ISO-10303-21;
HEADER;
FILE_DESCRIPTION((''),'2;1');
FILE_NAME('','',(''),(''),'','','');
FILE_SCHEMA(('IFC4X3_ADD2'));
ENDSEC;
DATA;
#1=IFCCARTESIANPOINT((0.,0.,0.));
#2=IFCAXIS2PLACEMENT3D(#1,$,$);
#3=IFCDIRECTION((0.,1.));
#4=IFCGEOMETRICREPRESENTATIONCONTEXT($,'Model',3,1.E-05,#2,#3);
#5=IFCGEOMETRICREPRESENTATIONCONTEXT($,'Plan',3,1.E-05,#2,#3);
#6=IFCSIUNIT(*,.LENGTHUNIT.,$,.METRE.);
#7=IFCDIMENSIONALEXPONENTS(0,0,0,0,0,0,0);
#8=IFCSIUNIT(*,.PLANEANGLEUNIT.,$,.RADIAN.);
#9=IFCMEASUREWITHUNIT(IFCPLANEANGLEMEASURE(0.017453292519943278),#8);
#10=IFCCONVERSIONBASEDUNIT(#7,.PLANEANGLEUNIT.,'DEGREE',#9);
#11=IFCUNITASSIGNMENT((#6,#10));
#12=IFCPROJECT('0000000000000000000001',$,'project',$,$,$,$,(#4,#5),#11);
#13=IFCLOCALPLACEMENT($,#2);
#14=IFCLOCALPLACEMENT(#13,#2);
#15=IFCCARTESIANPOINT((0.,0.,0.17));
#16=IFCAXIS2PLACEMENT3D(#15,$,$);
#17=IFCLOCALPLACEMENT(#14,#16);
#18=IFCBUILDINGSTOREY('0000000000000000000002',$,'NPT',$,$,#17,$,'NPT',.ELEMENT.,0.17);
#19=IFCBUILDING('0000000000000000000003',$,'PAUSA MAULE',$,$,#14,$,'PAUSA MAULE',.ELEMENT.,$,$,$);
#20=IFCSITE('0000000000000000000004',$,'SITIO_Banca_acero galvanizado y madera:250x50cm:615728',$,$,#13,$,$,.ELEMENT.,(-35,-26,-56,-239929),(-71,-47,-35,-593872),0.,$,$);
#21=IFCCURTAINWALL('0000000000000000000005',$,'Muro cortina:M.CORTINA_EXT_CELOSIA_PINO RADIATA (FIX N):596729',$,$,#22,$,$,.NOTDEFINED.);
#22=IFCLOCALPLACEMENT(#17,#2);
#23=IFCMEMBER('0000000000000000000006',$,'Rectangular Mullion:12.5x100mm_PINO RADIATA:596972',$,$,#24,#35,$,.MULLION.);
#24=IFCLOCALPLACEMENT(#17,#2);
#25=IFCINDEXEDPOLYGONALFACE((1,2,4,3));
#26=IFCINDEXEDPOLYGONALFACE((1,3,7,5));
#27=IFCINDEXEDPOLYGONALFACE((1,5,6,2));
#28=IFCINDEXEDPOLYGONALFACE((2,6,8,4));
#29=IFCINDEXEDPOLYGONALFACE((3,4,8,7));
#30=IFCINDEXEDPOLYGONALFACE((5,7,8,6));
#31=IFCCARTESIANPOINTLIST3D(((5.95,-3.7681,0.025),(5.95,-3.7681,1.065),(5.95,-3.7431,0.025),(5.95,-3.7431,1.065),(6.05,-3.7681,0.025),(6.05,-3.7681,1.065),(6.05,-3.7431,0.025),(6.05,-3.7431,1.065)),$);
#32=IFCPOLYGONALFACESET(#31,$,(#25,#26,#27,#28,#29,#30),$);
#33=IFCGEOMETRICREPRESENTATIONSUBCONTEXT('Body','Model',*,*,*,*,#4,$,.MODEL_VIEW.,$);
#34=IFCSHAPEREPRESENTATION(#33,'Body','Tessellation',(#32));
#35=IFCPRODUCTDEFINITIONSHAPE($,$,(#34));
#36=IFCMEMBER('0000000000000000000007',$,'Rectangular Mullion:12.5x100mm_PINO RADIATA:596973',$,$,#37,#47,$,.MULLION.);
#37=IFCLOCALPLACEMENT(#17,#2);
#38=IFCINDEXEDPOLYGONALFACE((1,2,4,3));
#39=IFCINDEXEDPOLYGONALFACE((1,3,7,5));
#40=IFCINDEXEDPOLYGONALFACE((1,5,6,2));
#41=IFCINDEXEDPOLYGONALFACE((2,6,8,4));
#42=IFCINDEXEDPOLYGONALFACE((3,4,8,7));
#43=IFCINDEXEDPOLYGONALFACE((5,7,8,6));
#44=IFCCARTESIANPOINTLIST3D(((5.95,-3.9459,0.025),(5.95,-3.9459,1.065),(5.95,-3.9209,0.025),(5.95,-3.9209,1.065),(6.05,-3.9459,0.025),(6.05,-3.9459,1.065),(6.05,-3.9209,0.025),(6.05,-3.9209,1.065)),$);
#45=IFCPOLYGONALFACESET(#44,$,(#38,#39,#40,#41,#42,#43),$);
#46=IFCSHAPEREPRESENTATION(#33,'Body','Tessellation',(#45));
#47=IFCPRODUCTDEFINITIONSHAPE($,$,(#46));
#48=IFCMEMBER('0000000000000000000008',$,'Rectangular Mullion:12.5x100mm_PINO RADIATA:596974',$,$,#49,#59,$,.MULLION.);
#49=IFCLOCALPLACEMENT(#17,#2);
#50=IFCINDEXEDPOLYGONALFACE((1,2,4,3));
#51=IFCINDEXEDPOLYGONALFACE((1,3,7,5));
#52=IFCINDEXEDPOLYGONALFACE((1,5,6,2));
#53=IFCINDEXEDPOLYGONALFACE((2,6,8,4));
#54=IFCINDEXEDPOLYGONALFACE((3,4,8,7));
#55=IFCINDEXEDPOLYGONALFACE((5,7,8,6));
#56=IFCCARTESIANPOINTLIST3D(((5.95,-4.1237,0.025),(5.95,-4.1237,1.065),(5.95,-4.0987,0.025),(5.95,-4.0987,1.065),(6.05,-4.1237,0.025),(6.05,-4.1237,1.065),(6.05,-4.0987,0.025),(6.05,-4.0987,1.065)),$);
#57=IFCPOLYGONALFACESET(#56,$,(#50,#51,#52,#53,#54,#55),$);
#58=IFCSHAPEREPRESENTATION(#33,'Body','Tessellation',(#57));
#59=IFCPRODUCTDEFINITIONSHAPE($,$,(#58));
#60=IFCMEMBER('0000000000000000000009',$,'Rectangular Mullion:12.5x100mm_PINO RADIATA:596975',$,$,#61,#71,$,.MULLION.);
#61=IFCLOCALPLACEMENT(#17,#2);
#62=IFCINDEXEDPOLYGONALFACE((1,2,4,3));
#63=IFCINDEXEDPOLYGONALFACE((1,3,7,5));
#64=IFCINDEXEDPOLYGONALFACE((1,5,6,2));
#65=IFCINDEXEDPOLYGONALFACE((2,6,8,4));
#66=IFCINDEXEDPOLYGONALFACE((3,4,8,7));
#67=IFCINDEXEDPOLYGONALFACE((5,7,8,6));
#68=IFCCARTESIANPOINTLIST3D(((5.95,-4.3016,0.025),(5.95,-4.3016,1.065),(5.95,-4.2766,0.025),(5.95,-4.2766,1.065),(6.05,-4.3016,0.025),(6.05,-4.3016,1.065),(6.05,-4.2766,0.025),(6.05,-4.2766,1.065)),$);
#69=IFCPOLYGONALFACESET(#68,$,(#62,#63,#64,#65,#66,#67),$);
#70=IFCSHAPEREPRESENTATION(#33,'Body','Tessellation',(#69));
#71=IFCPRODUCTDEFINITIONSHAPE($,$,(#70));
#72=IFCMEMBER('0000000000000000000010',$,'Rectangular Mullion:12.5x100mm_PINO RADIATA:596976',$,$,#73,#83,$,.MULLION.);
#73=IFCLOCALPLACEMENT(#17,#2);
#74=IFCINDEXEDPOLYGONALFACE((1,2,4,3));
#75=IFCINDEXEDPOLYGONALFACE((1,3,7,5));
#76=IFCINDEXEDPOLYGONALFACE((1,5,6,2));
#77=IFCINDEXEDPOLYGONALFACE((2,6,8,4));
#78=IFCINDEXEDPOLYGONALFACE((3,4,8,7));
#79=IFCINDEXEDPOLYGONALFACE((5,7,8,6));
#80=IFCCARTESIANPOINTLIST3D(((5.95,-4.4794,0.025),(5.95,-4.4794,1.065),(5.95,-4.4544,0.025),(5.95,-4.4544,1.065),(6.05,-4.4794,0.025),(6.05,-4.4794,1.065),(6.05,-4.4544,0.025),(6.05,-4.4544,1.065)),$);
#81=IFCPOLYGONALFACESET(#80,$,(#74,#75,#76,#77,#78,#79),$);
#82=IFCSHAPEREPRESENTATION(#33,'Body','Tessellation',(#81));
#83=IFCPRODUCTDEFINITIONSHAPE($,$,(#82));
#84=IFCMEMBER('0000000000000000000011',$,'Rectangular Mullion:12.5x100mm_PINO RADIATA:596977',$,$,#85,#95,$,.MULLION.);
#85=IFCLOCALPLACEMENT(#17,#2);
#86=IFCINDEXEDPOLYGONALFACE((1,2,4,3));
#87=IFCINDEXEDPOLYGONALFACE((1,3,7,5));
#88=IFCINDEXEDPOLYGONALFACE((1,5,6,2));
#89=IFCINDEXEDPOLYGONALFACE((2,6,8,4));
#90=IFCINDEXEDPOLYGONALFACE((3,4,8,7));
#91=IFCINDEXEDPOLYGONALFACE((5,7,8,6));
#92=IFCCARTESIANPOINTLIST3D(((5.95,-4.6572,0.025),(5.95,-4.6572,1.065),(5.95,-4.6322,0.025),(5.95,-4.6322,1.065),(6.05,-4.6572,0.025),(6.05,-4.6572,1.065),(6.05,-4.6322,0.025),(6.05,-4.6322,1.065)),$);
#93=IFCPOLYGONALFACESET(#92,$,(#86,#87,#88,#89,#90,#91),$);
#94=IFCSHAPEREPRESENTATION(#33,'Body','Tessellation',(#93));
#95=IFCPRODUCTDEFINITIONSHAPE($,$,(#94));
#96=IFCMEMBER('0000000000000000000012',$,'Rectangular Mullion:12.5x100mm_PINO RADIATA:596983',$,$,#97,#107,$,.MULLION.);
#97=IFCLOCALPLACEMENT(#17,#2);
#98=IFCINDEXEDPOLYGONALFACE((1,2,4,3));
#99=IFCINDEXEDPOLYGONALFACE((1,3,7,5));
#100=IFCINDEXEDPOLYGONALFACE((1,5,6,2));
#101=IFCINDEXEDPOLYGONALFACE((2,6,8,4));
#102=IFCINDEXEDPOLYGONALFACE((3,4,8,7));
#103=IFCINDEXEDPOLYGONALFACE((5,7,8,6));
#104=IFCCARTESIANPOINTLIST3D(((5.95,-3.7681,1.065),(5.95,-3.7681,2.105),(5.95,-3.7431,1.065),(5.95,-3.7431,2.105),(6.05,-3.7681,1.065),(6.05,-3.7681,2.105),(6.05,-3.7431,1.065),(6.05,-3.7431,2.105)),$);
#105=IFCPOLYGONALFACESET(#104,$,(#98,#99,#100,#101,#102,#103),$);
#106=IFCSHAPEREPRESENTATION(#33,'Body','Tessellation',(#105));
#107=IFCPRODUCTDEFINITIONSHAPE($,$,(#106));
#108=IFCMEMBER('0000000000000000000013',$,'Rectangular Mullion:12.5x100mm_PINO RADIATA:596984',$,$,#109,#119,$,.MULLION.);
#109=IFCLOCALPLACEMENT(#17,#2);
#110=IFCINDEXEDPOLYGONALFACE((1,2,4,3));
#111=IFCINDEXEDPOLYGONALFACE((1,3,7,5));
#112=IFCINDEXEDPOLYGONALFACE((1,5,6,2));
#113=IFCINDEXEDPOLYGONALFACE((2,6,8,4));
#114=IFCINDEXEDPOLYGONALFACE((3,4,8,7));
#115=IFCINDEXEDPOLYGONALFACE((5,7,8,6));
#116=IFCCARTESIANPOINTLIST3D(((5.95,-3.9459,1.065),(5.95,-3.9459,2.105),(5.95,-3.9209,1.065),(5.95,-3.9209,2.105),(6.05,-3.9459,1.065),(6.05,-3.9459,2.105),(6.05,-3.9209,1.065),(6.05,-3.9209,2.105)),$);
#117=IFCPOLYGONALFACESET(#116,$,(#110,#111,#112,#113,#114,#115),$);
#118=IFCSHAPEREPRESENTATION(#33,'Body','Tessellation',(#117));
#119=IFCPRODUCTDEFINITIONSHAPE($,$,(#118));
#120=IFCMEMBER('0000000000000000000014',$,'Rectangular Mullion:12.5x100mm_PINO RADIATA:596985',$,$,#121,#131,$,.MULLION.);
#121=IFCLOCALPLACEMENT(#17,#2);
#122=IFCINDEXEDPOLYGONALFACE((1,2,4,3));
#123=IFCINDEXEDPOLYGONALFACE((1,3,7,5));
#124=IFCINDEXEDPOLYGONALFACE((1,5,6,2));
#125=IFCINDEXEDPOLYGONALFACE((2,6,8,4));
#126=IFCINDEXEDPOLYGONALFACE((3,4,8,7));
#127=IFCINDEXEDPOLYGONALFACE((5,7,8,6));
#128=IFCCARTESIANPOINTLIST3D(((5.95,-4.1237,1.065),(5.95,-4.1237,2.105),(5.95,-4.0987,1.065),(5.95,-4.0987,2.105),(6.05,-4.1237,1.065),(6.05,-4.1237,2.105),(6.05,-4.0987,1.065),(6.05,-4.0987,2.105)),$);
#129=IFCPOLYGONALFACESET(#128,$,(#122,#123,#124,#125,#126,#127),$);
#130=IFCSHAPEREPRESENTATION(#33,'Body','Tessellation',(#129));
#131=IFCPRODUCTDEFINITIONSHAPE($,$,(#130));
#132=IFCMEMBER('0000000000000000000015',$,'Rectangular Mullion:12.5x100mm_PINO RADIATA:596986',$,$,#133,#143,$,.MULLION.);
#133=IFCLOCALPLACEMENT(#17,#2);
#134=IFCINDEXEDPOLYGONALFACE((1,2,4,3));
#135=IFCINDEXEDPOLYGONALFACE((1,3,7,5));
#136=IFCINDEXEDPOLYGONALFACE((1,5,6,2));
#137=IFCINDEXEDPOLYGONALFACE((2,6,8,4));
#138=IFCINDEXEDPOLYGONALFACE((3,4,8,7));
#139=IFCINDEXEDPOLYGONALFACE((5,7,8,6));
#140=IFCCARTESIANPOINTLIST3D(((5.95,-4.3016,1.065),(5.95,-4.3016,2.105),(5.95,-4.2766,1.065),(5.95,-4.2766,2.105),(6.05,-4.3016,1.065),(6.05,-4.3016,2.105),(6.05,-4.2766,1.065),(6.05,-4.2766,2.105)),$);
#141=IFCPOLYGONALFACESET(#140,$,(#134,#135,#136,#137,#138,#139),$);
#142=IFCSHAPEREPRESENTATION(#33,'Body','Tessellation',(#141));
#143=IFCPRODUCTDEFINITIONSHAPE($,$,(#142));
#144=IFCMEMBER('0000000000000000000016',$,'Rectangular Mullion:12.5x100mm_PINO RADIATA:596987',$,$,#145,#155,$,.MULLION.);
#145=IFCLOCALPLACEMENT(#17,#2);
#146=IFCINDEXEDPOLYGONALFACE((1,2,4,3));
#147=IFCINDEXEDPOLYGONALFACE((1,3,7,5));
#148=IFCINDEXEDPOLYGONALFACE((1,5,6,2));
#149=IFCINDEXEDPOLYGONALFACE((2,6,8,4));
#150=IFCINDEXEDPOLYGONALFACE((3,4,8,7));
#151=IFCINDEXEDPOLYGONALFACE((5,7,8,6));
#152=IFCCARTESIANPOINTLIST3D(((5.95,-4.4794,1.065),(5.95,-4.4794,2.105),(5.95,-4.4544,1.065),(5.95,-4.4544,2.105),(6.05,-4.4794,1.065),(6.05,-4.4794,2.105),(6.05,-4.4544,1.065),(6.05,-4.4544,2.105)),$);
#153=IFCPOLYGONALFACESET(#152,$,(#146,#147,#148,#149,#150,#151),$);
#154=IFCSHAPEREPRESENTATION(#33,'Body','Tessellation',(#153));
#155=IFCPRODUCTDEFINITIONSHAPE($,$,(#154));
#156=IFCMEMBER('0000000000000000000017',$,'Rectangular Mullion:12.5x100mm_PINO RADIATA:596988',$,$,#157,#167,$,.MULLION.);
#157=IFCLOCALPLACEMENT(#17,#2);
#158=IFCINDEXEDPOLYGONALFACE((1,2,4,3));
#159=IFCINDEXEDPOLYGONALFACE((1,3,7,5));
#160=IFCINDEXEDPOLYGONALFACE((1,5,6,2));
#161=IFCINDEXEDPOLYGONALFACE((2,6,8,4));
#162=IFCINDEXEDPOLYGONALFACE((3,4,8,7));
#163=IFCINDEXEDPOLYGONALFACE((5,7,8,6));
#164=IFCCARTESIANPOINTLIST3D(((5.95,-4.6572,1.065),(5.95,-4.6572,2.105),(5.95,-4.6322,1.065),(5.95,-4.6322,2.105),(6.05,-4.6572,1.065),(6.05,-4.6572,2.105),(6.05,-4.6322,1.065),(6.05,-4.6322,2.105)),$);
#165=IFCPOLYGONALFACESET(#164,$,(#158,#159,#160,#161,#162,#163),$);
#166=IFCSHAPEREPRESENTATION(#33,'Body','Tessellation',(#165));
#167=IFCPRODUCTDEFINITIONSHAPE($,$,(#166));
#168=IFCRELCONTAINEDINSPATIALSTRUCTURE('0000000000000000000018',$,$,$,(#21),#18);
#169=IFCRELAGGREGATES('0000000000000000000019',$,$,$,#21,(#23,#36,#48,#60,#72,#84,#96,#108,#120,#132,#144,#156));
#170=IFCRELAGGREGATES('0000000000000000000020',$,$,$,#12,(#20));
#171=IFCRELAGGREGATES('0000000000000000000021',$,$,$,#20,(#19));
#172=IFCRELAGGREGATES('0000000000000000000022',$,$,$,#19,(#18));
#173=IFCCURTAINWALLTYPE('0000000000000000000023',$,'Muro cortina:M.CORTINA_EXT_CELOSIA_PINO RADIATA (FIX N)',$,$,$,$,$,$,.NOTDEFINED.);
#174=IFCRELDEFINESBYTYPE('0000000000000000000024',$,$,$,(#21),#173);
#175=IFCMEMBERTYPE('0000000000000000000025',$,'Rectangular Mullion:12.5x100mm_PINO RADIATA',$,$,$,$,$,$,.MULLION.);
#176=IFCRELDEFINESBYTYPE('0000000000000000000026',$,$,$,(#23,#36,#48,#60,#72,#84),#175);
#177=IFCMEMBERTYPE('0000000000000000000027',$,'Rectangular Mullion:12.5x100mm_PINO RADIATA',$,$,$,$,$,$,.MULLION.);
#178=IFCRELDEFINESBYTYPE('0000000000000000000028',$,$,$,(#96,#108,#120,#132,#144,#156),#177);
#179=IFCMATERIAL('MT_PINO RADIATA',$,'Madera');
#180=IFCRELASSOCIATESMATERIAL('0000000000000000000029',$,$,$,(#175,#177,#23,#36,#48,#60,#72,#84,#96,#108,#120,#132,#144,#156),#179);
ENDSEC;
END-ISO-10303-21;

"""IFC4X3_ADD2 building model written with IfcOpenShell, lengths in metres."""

from ifc_helpers import new_model, entity, si_unit, converted_unit, direction, frame, frame_2d, origin, origin_2d_with_axis, place, context, subcontext, project, spatial, rectangle, extrude, source, transform, mapped, material, material_profile, profile_set, profile_usage, type_object, type_shapes, element, aggregate, save


model = new_model("IFC4X3_ADD2")

# Units and contexts
model_context = context("Model", 3, precision=1e-05, world=origin(), true_north=direction((0.0, 1.0)))
plan_context = context("Plan", 3, precision=1e-05, world=origin(), true_north=direction((0.0, 1.0)))
body_context = subcontext(model_context, "Body", "Model", "MODEL_VIEW")
ifc_project = project(units=[si_unit("LENGTHUNIT", "METRE"), converted_unit("PLANEANGLEUNIT", "DEGREE", entity("IfcPlaneAngleMeasure", 0.017453292519943278), si_unit("PLANEANGLEUNIT", "RADIAN"), dimensions=[0, 0, 0, 0, 0, 0, 0])], contexts=[model_context, plan_context])

# Site, building, storey
site_placement = place(None, origin())
site = spatial("IfcSite", under=ifc_project, at=site_placement, Name="SITIO_Banca_acero galvanizado y madera:250x50cm:615728", CompositionType="ELEMENT", RefLatitude=(-35, -26, -56, -239929), RefLongitude=(-71, -47, -35, -593872), RefElevation=0.0)
building_placement = place(site_placement, origin())
building = spatial("IfcBuilding", under=site, at=building_placement, Name="PAUSA MAULE", LongName="PAUSA MAULE", CompositionType="ELEMENT")
storey_placement = place(building_placement, frame((0.0, 0.0, 0.17)))
storey = spatial("IfcBuildingStorey", under=building, at=storey_placement, Name="NPT", LongName="NPT", CompositionType="ELEMENT", Elevation=0.17)

# Curtain wall, members
curtain_wall_type = type_object("IfcCurtainWallType", Name="Muro cortina:M.CORTINA_EXT_CELOSIA_PINO RADIATA (FIX N)", PredefinedType="NOTDEFINED")
curtain_wall_placement = place(storey_placement, frame((0.0, 0.0, -0.17)))
curtain_wall = element("IfcCurtainWall", 1, at=curtain_wall_placement, inside=storey, type_object=curtain_wall_type, Name="Muro cortina:M.CORTINA_EXT_CELOSIA_PINO RADIATA (FIX N):596729", PredefinedType="NOTDEFINED")
ifc_material = material(Name="MT_PINO RADIATA", Category="Madera")
ifc_material_profile = material_profile(ifc_material, rectangle(XDim=0.025, YDim=0.1, at=frame_2d((0.0, 0.0), x_axis=(1.0, 0.0))), Name="12.5x100mm_PINO RADIATA")
ifc_profile_set = profile_set([ifc_material_profile], Name="12.5x100mm_PINO RADIATA")
ifc_profile_usage = profile_usage(ifc_profile_set)
member_type_1 = type_object("IfcMemberType", Name="Rectangular Mullion:12.5x100mm_PINO RADIATA", PredefinedType="MULLION", material=ifc_profile_set)
shared_shape_1 = source(origin(), body_context, "Body", "SweptSolid", [
    extrude(rectangle(XDim=0.025, YDim=0.1, at=frame_2d((0.0, 0.0), x_axis=(1.0, 0.0))), frame((0.0, 0.0, -1.04), z_axis=(0.0, 0.0, 1.0), x_axis=(-1.0, 0.0, 0.0)), (0.0, 0.0, 1.0), 1.04),
])
type_shapes(member_type_1, [shared_shape_1])
member_1_placement = place(curtain_wall_placement, frame((6.0, -3.7556, 0.195), z_axis=(0.0, 0.0, -1.0), x_axis=(0.0, -1.0, 0.0)))
member_1 = element("IfcMember", 2, at=member_1_placement, type_object=member_type_1, material=ifc_profile_usage, Name="Rectangular Mullion:12.5x100mm_PINO RADIATA:596972", PredefinedType="MULLION", context=body_context, shape_type="MappedRepresentation", body=[
    mapped(shared_shape_1, transform((0.0, 0.0, 0.0), scale=1.0)),
])
member_2_placement = place(curtain_wall_placement, frame((6.0, -3.9334, 0.195), z_axis=(0.0, 0.0, -1.0), x_axis=(0.0, -1.0, 0.0)))
member_2 = element("IfcMember", 3, at=member_2_placement, type_object=member_type_1, material=ifc_profile_usage, Name="Rectangular Mullion:12.5x100mm_PINO RADIATA:596973", PredefinedType="MULLION", context=body_context, shape_type="MappedRepresentation", body=[
    mapped(shared_shape_1, transform((0.0, 0.0, 0.0), scale=1.0)),
])
member_3_placement = place(curtain_wall_placement, frame((6.0, -4.1112, 0.195), z_axis=(0.0, 0.0, -1.0), x_axis=(0.0, -1.0, 0.0)))
member_3 = element("IfcMember", 4, at=member_3_placement, type_object=member_type_1, material=ifc_profile_usage, Name="Rectangular Mullion:12.5x100mm_PINO RADIATA:596974", PredefinedType="MULLION", context=body_context, shape_type="MappedRepresentation", body=[
    mapped(shared_shape_1, transform((0.0, 0.0, 0.0), scale=1.0)),
])
member_4_placement = place(curtain_wall_placement, frame((6.0, -4.2891, 0.195), z_axis=(0.0, 0.0, -1.0), x_axis=(0.0, -1.0, 0.0)))
member_4 = element("IfcMember", 5, at=member_4_placement, type_object=member_type_1, material=ifc_profile_usage, Name="Rectangular Mullion:12.5x100mm_PINO RADIATA:596975", PredefinedType="MULLION", context=body_context, shape_type="MappedRepresentation", body=[
    mapped(shared_shape_1, transform((0.0, 0.0, 0.0), scale=1.0)),
])
member_5_placement = place(curtain_wall_placement, frame((6.0, -4.4669, 0.195), z_axis=(0.0, 0.0, -1.0), x_axis=(0.0, -1.0, 0.0)))
member_5 = element("IfcMember", 6, at=member_5_placement, type_object=member_type_1, material=ifc_profile_usage, Name="Rectangular Mullion:12.5x100mm_PINO RADIATA:596976", PredefinedType="MULLION", context=body_context, shape_type="MappedRepresentation", body=[
    mapped(shared_shape_1, transform((0.0, 0.0, 0.0), scale=1.0)),
])
member_6_placement = place(curtain_wall_placement, frame((6.0, -4.6447, 0.195), z_axis=(0.0, 0.0, -1.0), x_axis=(0.0, -1.0, 0.0)))
member_6 = element("IfcMember", 7, at=member_6_placement, type_object=member_type_1, material=ifc_profile_usage, Name="Rectangular Mullion:12.5x100mm_PINO RADIATA:596977", PredefinedType="MULLION", context=body_context, shape_type="MappedRepresentation", body=[
    mapped(shared_shape_1, transform((0.0, 0.0, 0.0), scale=1.0)),
])
member_type_2 = type_object("IfcMemberType", Name="Rectangular Mullion:12.5x100mm_PINO RADIATA", PredefinedType="MULLION", material=ifc_profile_set)
shared_shape_2 = source(origin(), body_context, "Body", "SweptSolid", [
    extrude(rectangle(XDim=0.025, YDim=0.1, at=origin_2d_with_axis()), frame((0.0, 0.0, -1.04), z_axis=(0.0, 0.0, 1.0), x_axis=(-1.0, 0.0, 0.0)), (0.0, 0.0, 1.0), 1.04),
])
type_shapes(member_type_2, [shared_shape_2])
member_7_placement = place(curtain_wall_placement, frame((6.0, -3.7556, 1.235), z_axis=(0.0, 0.0, -1.0), x_axis=(0.0, -1.0, 0.0)))
member_7 = element("IfcMember", 8, at=member_7_placement, type_object=member_type_2, material=ifc_profile_usage, Name="Rectangular Mullion:12.5x100mm_PINO RADIATA:596983", PredefinedType="MULLION", context=body_context, shape_type="MappedRepresentation", body=[
    mapped(shared_shape_2, transform((0.0, 0.0, 0.0), scale=1.0)),
])
member_8_placement = place(curtain_wall_placement, frame((6.0, -3.9334, 1.235), z_axis=(0.0, 0.0, -1.0), x_axis=(0.0, -1.0, 0.0)))
member_8 = element("IfcMember", 9, at=member_8_placement, type_object=member_type_2, material=ifc_profile_usage, Name="Rectangular Mullion:12.5x100mm_PINO RADIATA:596984", PredefinedType="MULLION", context=body_context, shape_type="MappedRepresentation", body=[
    mapped(shared_shape_2, transform((0.0, 0.0, 0.0), scale=1.0)),
])
member_9_placement = place(curtain_wall_placement, frame((6.0, -4.1112, 1.235), z_axis=(0.0, 0.0, -1.0), x_axis=(0.0, -1.0, 0.0)))
member_9 = element("IfcMember", 10, at=member_9_placement, type_object=member_type_2, material=ifc_profile_usage, Name="Rectangular Mullion:12.5x100mm_PINO RADIATA:596985", PredefinedType="MULLION", context=body_context, shape_type="MappedRepresentation", body=[
    mapped(shared_shape_2, transform((0.0, 0.0, 0.0), scale=1.0)),
])
member_10_placement = place(curtain_wall_placement, frame((6.0, -4.2891, 1.235), z_axis=(0.0, 0.0, -1.0), x_axis=(0.0, -1.0, 0.0)))
member_10 = element("IfcMember", 11, at=member_10_placement, type_object=member_type_2, material=ifc_profile_usage, Name="Rectangular Mullion:12.5x100mm_PINO RADIATA:596986", PredefinedType="MULLION", context=body_context, shape_type="MappedRepresentation", body=[
    mapped(shared_shape_2, transform((0.0, 0.0, 0.0), scale=1.0)),
])
member_11_placement = place(curtain_wall_placement, frame((6.0, -4.4669, 1.235), z_axis=(0.0, 0.0, -1.0), x_axis=(0.0, -1.0, 0.0)))
member_11 = element("IfcMember", 12, at=member_11_placement, type_object=member_type_2, material=ifc_profile_usage, Name="Rectangular Mullion:12.5x100mm_PINO RADIATA:596987", PredefinedType="MULLION", context=body_context, shape_type="MappedRepresentation", body=[
    mapped(shared_shape_2, transform((0.0, 0.0, 0.0), scale=1.0)),
])
member_12_placement = place(curtain_wall_placement, frame((6.0, -4.6447, 1.235), z_axis=(0.0, 0.0, -1.0), x_axis=(0.0, -1.0, 0.0)))
member_12 = element("IfcMember", 13, at=member_12_placement, type_object=member_type_2, material=ifc_profile_usage, Name="Rectangular Mullion:12.5x100mm_PINO RADIATA:596988", PredefinedType="MULLION", context=body_context, shape_type="MappedRepresentation", body=[
    mapped(shared_shape_2, transform((0.0, 0.0, 0.0), scale=1.0)),
])
aggregate(curtain_wall, [member_1, member_2, member_3, member_4, member_5, member_6, member_7, member_8, member_9, member_10, member_11, member_12])

save(model, "model.ifc")
